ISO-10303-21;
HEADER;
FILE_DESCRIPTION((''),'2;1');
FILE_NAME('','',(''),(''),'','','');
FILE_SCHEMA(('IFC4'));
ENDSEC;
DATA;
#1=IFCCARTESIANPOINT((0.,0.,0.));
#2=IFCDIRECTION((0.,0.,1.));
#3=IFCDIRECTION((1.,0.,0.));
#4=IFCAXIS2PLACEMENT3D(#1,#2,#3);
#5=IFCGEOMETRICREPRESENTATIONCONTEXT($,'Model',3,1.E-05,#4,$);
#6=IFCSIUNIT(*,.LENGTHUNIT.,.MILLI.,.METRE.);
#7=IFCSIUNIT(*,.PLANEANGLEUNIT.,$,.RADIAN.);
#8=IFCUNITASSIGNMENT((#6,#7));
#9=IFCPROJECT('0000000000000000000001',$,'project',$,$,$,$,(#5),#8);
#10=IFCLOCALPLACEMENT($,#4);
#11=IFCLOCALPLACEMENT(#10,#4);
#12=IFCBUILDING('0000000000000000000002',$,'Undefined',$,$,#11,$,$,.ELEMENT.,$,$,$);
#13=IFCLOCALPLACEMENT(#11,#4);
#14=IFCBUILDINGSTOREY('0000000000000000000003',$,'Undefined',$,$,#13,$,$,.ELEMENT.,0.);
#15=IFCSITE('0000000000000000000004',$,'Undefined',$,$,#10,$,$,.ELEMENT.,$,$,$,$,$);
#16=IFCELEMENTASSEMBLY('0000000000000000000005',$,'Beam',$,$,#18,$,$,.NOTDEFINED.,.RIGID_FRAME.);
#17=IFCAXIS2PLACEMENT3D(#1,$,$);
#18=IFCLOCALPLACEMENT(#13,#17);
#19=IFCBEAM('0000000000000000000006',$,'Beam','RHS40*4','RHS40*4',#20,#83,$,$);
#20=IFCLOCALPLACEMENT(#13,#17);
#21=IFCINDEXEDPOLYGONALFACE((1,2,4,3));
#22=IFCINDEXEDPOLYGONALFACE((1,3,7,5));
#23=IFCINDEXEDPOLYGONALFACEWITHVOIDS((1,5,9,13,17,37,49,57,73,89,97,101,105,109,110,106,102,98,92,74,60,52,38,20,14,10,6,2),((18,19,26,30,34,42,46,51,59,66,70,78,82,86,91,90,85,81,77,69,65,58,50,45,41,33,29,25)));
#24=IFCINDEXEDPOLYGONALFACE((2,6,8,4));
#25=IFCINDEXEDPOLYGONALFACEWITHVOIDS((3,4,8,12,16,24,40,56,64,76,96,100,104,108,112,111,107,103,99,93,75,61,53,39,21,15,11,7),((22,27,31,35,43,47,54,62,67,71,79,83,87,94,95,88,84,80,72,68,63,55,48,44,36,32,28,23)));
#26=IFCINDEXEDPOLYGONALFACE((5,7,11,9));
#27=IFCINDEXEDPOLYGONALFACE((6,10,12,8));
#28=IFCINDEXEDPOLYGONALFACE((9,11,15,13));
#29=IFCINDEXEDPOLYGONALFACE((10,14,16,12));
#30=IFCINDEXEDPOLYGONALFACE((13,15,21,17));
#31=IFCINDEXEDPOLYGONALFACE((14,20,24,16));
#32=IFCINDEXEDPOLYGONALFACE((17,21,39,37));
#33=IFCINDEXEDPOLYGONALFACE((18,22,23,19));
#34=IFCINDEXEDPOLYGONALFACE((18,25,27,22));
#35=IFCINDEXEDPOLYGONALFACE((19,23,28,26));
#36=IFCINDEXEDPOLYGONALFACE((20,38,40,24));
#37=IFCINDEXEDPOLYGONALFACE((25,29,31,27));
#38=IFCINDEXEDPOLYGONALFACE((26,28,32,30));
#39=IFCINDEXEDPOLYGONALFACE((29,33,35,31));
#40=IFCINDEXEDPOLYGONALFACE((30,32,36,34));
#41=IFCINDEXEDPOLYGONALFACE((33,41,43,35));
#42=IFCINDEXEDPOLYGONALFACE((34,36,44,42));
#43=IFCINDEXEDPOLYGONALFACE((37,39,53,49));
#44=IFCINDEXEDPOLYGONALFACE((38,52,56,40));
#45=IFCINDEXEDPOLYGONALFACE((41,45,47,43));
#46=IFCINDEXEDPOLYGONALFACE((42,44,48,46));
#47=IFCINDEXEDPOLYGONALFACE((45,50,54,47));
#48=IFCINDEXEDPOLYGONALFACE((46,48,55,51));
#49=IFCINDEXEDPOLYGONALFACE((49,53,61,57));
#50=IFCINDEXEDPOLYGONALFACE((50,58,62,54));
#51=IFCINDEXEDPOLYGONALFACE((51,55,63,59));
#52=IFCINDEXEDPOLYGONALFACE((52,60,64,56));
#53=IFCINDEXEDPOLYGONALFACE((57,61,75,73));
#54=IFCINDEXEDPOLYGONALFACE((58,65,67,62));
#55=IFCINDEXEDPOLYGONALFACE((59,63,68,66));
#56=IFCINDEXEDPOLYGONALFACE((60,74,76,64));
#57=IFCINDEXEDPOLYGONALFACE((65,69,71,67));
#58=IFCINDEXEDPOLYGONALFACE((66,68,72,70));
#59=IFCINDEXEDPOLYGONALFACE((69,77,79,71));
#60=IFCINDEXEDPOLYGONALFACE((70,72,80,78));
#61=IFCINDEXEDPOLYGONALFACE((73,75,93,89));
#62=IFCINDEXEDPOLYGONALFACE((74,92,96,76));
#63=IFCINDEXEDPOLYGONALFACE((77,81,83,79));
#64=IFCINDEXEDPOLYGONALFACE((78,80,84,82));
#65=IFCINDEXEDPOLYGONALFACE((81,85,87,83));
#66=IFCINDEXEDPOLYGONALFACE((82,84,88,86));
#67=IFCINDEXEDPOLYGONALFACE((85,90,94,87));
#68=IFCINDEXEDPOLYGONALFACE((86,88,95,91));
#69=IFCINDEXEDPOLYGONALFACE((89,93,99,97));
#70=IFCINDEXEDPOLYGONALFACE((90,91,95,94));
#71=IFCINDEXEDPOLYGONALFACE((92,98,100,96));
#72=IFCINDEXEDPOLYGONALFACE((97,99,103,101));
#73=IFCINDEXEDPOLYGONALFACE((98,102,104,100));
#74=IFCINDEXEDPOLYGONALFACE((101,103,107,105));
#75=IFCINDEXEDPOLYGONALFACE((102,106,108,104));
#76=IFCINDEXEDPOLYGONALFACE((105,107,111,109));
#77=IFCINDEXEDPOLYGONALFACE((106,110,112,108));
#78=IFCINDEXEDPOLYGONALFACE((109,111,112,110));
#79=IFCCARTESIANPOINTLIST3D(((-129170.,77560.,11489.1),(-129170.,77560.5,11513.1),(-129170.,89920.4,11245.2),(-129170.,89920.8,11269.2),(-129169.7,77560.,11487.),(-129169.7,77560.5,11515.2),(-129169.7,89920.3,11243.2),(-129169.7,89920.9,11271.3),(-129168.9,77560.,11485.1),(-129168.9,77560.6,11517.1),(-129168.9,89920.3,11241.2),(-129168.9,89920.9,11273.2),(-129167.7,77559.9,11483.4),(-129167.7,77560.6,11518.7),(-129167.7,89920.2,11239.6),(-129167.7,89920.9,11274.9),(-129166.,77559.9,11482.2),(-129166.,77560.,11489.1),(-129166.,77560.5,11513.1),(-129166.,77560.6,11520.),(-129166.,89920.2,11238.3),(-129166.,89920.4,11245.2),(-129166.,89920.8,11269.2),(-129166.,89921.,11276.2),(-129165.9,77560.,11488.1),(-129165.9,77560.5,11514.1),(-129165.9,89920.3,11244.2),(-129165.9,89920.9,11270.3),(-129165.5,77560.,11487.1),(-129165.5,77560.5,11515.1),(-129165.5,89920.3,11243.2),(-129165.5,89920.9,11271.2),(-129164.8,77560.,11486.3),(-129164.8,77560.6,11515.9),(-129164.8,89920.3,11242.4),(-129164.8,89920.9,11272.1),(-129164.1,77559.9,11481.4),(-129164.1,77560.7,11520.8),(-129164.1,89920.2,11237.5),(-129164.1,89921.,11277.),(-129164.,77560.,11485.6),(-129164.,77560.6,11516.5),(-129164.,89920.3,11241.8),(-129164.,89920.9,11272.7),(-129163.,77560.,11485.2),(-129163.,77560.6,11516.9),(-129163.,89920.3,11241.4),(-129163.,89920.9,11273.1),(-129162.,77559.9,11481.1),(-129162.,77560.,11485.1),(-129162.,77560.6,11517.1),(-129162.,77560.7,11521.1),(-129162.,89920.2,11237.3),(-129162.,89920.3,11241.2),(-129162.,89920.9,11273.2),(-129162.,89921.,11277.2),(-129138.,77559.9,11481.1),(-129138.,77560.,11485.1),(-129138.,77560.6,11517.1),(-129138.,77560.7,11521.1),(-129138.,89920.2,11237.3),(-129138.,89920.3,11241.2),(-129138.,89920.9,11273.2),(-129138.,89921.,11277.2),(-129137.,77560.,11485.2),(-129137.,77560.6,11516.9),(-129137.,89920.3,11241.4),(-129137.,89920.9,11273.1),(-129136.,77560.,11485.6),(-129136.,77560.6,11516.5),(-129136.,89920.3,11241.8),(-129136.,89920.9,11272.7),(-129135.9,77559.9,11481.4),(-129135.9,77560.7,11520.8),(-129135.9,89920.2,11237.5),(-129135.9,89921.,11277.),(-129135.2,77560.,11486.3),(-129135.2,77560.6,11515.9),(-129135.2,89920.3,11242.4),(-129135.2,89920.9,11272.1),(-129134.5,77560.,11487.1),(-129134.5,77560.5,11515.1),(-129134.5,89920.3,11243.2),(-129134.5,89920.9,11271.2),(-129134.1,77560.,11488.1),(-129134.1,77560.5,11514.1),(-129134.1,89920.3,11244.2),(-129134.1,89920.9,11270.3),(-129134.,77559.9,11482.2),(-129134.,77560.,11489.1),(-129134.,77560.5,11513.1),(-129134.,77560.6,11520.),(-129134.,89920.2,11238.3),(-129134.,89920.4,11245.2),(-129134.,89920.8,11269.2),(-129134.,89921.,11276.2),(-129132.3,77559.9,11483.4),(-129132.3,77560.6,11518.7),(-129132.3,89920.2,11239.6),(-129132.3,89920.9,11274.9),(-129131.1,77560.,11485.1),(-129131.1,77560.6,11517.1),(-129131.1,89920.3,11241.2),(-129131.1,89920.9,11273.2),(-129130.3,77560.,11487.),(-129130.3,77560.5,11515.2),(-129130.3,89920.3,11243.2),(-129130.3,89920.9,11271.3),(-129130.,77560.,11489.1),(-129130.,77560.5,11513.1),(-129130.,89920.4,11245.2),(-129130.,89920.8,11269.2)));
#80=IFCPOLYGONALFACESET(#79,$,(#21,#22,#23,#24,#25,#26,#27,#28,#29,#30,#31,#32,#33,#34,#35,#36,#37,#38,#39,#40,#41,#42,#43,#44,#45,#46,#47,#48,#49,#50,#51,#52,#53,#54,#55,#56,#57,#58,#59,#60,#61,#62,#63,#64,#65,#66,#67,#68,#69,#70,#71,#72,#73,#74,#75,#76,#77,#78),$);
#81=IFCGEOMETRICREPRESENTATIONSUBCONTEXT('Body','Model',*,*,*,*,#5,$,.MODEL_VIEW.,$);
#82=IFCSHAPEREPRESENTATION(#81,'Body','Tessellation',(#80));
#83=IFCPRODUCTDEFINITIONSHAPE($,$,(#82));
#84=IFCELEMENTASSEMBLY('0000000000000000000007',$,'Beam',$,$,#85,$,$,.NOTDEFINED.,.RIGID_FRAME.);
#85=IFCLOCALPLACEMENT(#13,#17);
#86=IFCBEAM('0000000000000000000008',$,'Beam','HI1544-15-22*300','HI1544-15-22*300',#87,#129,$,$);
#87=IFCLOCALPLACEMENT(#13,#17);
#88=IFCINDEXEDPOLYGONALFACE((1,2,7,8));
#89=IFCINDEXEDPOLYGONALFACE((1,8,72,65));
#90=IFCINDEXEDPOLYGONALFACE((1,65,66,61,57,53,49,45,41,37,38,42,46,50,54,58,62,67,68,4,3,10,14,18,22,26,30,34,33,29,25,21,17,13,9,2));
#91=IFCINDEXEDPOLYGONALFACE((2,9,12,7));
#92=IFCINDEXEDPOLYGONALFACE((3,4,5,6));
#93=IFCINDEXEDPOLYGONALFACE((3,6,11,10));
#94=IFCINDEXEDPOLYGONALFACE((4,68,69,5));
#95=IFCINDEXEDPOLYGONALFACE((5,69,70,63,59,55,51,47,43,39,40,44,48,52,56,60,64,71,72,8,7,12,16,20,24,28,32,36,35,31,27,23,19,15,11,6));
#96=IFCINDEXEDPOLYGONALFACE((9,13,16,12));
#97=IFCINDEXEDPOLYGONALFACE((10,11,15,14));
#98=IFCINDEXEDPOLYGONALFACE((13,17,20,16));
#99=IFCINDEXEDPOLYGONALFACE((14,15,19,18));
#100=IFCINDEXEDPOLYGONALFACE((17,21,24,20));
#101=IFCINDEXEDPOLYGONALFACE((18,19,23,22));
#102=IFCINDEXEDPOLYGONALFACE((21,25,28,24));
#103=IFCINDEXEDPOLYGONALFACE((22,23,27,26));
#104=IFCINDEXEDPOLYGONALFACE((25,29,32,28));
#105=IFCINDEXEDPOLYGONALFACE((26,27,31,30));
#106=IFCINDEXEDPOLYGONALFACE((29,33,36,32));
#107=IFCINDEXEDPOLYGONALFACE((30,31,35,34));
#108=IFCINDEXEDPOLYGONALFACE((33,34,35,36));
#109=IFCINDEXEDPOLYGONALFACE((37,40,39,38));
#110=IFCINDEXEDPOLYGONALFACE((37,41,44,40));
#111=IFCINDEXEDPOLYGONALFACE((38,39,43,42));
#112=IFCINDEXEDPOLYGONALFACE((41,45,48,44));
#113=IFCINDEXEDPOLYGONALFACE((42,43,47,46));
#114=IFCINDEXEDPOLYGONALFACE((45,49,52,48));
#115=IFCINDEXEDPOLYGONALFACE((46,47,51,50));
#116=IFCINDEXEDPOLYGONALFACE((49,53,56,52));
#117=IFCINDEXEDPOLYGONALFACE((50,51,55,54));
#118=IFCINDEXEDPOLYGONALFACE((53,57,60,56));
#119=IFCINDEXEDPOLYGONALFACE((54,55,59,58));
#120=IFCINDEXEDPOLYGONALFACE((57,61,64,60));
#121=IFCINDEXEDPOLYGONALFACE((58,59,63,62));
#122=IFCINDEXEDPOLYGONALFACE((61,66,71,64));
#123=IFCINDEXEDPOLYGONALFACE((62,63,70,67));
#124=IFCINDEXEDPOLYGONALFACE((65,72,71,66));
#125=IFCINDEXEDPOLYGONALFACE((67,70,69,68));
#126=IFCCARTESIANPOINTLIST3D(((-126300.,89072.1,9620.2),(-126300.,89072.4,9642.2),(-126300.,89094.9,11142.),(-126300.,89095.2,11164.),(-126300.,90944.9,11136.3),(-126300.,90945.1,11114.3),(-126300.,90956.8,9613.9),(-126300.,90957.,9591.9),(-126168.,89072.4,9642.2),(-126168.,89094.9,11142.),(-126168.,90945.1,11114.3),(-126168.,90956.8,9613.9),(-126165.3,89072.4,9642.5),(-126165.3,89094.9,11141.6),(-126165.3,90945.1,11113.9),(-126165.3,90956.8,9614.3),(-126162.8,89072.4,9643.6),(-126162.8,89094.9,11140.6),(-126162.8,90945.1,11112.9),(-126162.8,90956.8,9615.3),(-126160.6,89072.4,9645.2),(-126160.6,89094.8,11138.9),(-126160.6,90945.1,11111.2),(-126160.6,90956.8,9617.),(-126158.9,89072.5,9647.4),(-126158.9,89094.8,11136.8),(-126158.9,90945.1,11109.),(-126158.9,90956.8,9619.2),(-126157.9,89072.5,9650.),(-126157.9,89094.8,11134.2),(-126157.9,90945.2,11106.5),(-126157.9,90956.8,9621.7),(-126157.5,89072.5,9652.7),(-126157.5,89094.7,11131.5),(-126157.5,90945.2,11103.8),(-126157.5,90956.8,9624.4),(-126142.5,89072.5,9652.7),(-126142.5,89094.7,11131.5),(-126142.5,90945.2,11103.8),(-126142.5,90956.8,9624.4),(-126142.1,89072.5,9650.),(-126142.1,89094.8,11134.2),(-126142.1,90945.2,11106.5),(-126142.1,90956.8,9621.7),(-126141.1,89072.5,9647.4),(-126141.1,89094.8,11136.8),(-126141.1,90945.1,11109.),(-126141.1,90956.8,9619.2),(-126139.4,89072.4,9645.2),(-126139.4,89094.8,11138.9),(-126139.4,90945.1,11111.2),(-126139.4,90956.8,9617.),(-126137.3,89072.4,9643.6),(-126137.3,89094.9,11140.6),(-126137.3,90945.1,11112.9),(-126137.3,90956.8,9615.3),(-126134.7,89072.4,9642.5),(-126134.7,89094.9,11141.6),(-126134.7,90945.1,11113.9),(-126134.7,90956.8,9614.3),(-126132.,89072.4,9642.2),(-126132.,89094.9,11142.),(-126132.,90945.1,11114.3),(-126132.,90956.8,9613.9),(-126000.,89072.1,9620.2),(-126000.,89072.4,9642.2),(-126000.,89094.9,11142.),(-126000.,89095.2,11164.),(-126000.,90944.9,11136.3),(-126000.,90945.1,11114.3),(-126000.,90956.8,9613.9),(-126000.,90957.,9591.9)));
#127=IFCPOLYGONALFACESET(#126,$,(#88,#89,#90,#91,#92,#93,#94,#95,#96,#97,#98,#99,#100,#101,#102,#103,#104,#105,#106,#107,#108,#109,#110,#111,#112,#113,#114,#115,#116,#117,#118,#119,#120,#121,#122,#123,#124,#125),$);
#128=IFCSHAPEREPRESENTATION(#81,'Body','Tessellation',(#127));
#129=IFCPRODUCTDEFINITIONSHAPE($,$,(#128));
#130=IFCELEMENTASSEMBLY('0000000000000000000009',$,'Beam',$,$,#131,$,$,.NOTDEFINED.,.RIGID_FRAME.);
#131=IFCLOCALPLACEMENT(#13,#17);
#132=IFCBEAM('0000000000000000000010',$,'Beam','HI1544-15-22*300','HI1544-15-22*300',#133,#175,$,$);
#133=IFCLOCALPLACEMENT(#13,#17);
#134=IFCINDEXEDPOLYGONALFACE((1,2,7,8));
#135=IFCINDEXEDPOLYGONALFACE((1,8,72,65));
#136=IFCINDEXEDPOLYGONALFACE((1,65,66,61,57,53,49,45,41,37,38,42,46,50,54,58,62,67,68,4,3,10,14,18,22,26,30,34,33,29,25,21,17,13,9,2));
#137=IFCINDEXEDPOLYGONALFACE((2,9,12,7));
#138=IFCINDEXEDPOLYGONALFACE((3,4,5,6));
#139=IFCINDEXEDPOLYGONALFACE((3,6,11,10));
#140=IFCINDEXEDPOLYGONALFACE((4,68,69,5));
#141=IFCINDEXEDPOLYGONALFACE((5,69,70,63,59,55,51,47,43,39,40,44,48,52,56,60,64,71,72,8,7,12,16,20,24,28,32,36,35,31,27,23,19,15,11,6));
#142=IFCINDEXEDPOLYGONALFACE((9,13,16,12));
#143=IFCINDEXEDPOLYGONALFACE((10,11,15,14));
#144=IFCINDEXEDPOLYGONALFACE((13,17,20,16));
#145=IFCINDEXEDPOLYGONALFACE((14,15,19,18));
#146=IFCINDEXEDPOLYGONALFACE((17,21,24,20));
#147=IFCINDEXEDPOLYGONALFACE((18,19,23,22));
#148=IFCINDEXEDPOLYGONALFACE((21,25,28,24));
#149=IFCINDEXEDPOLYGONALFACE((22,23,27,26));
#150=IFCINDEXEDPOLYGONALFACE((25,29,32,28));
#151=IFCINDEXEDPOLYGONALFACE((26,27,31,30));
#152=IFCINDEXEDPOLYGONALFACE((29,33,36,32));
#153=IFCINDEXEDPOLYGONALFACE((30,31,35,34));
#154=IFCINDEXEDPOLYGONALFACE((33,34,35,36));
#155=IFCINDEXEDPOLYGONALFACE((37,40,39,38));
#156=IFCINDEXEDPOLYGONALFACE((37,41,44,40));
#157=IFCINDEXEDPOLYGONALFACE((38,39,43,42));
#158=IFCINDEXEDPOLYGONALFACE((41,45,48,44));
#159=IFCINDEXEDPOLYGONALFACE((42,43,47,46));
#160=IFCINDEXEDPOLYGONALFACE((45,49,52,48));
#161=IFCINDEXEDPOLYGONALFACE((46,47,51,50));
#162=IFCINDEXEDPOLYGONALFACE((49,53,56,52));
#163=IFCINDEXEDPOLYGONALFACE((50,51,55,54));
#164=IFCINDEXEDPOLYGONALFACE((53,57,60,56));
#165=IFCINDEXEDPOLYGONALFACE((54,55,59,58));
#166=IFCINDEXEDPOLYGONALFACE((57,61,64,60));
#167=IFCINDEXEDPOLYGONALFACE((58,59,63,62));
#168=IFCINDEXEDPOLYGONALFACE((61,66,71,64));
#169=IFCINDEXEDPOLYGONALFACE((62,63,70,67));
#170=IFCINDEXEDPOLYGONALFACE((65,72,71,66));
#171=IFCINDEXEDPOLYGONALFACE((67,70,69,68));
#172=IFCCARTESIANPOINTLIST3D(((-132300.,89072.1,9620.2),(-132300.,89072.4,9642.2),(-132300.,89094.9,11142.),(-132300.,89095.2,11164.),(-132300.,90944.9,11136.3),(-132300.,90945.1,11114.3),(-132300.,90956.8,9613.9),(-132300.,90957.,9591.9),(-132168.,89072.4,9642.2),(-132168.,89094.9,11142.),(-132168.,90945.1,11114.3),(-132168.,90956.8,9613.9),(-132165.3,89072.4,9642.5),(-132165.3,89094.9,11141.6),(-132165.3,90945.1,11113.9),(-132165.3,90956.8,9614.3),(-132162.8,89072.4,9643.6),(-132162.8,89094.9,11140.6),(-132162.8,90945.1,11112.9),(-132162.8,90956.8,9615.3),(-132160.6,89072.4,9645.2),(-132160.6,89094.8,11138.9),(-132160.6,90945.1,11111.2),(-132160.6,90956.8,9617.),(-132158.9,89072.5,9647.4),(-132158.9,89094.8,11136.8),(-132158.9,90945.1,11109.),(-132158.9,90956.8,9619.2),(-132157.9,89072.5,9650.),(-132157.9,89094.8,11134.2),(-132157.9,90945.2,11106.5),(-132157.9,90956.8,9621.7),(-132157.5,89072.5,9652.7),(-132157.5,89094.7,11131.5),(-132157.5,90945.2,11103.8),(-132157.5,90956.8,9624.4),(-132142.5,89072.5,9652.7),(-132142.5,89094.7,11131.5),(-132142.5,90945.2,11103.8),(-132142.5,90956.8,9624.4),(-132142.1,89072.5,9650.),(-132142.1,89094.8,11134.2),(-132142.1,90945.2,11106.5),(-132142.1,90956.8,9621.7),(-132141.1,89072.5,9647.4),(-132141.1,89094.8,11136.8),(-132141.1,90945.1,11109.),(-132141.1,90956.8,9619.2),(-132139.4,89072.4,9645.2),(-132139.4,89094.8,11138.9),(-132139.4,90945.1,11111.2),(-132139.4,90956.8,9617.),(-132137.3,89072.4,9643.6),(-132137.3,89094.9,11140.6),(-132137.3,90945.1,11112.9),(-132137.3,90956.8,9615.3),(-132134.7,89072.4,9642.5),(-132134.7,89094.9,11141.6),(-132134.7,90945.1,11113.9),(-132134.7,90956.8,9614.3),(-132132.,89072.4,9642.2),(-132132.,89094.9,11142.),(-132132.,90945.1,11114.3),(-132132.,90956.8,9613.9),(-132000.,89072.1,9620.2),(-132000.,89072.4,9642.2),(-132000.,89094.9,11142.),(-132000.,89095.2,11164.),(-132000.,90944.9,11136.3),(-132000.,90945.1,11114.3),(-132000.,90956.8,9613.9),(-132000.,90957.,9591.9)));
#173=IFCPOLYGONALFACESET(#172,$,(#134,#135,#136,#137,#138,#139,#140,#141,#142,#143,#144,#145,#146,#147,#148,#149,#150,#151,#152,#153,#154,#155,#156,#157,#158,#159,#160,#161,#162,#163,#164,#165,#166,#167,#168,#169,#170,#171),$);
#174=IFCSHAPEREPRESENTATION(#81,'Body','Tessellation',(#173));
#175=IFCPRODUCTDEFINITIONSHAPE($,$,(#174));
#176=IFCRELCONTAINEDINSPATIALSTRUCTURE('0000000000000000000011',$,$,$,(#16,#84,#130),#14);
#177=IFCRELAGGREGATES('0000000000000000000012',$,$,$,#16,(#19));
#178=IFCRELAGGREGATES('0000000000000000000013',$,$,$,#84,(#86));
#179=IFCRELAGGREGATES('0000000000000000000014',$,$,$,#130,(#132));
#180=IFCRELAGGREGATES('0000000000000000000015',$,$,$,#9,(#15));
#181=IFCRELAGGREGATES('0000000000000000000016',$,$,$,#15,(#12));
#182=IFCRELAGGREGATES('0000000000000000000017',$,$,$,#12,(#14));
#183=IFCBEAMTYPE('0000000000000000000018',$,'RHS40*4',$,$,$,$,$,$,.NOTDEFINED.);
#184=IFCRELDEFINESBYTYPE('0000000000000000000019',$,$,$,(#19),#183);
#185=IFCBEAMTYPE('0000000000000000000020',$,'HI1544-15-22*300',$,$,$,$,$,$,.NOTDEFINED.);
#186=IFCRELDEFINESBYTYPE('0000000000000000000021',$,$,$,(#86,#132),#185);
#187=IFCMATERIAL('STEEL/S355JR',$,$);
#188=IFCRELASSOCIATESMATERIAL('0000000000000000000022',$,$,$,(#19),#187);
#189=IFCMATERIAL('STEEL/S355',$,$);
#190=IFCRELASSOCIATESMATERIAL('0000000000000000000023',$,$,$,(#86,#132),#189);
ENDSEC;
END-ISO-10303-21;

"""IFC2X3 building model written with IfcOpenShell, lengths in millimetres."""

from ifc_helpers import new_model, si_unit, frame, origin_with_axes, origin_2d_with_axis, place, context, subcontext, project, spatial, hollow_rectangle, i_section, extrude, clip, halfspace, material, type_object, element, aggregate, save


model = new_model("IFC2X3")

# Units and contexts
model_context = context("Model", 3, precision=1e-05, world=origin_with_axes())
body_context = subcontext(model_context, "Body", "Model", "MODEL_VIEW")
ifc_project = project(units=[si_unit("LENGTHUNIT", "METRE", prefix="MILLI"), si_unit("PLANEANGLEUNIT", "RADIAN")], contexts=[model_context])

# Site, building, storey
site_placement = place(None, origin_with_axes())
site = spatial("IfcSite", under=ifc_project, at=site_placement, Name="Undefined", CompositionType="ELEMENT")
building_placement = place(site_placement, origin_with_axes())
building = spatial("IfcBuilding", under=site, at=building_placement, Name="Undefined", CompositionType="ELEMENT")
storey_placement = place(building_placement, origin_with_axes())
storey = spatial("IfcBuildingStorey", under=building, at=storey_placement, Name="Undefined", CompositionType="ELEMENT", Elevation=0.0)

# Element assemblies, beams
ifc_material_1 = material(Name="STEEL/S355")
assembly_1_placement = place(storey_placement, origin_with_axes())
assembly_1 = element("IfcElementAssembly", 1, at=assembly_1_placement, inside=storey, Name="Beam", AssemblyPlace="NOTDEFINED", PredefinedType="RIGID_FRAME")
ifc_material_2 = material(Name="STEEL/S355JR")
beam_type_1 = type_object("IfcBeamType", Name="RHS40*4", PredefinedType="NOTDEFINED")
beam_1_placement = place(assembly_1_placement, frame((-129150.0, 77560.3, 11501.1), z_axis=(0.0, 0.019724, 0.999805), x_axis=(0.0, 0.999805, -0.019724)))
beam_1 = element("IfcBeam", 2, at=beam_1_placement, type_object=beam_type_1, material=ifc_material_2, Name="Beam", Description="RHS40*4", ObjectType="RHS40*4", context=body_context, shape_type="SweptSolid", body=[
    extrude(hollow_rectangle(XDim=40.0, YDim=40.0, WallThickness=4.0, InnerFilletRadius=4.0, OuterFilletRadius=8.0, at=origin_2d_with_axis()), frame((12362.7, 0.0, 0.0), z_axis=(-1.0, 0.0, 0.0), x_axis=(0.0, -1.0, 0.0)), (0.0, 0.0, 1.0), 12362.7),
])
aggregate(assembly_1, [beam_1])
assembly_2_placement = place(storey_placement, origin_with_axes())
assembly_2 = element("IfcElementAssembly", 3, at=assembly_2_placement, inside=storey, Name="Beam", AssemblyPlace="NOTDEFINED", PredefinedType="RIGID_FRAME")
beam_type_2 = type_object("IfcBeamType", Name="HI1544-15-22*300", PredefinedType="NOTDEFINED")
beam_2_placement = place(assembly_2_placement, frame((-126150.0, 89083.6, 10392.1), z_axis=(0.0, 0.014993, 0.999888), x_axis=(0.0, 0.999888, -0.014993)))
beam_2 = element("IfcBeam", 4, at=beam_2_placement, type_object=beam_type_2, material=ifc_material_1, Name="Beam", Description="HI1544-15-22*300", ObjectType="HI1544-15-22*300", context=body_context, shape_type="Clipping", body=[
    clip(extrude(i_section(OverallWidth=300.0, OverallDepth=1544.0, WebThickness=15.0, FlangeThickness=22.0, FilletRadius=10.5, at=origin_2d_with_axis()), frame((1897.0, 0.0, 0.0), z_axis=(-1.0, 0.0, 0.0), x_axis=(0.0, -1.0, 0.0)), (0.0, 0.0, 1.0), 1897.0), halfspace(frame((1885.2, -150.0, -772.0), z_axis=(0.99974, 0.0, 0.022818), x_axis=(-0.022818, 0.0, 0.99974)), False)),
])
aggregate(assembly_2, [beam_2])
assembly_3_placement = place(storey_placement, origin_with_axes())
assembly_3 = element("IfcElementAssembly", 5, at=assembly_3_placement, inside=storey, Name="Beam", AssemblyPlace="NOTDEFINED", PredefinedType="RIGID_FRAME")
beam_3_placement = place(assembly_3_placement, frame((-132150.0, 89083.6, 10392.1), z_axis=(0.0, 0.014993, 0.999888), x_axis=(0.0, 0.999888, -0.014993)))
beam_3 = element("IfcBeam", 6, at=beam_3_placement, type_object=beam_type_2, material=ifc_material_1, Name="Beam", Description="HI1544-15-22*300", ObjectType="HI1544-15-22*300", context=body_context, shape_type="Clipping", body=[
    clip(extrude(i_section(OverallWidth=300.0, OverallDepth=1544.0, WebThickness=15.0, FlangeThickness=22.0, FilletRadius=10.5, at=origin_2d_with_axis()), frame((1897.0, 0.0, 0.0), z_axis=(-1.0, 0.0, 0.0), x_axis=(0.0, -1.0, 0.0)), (0.0, 0.0, 1.0), 1897.0), halfspace(frame((1885.2, -150.0, -772.0), z_axis=(0.99974, 0.0, 0.022818), x_axis=(-0.022818, 0.0, 0.99974)), False)),
])
aggregate(assembly_3, [beam_3])

save(model, "model.ifc")
